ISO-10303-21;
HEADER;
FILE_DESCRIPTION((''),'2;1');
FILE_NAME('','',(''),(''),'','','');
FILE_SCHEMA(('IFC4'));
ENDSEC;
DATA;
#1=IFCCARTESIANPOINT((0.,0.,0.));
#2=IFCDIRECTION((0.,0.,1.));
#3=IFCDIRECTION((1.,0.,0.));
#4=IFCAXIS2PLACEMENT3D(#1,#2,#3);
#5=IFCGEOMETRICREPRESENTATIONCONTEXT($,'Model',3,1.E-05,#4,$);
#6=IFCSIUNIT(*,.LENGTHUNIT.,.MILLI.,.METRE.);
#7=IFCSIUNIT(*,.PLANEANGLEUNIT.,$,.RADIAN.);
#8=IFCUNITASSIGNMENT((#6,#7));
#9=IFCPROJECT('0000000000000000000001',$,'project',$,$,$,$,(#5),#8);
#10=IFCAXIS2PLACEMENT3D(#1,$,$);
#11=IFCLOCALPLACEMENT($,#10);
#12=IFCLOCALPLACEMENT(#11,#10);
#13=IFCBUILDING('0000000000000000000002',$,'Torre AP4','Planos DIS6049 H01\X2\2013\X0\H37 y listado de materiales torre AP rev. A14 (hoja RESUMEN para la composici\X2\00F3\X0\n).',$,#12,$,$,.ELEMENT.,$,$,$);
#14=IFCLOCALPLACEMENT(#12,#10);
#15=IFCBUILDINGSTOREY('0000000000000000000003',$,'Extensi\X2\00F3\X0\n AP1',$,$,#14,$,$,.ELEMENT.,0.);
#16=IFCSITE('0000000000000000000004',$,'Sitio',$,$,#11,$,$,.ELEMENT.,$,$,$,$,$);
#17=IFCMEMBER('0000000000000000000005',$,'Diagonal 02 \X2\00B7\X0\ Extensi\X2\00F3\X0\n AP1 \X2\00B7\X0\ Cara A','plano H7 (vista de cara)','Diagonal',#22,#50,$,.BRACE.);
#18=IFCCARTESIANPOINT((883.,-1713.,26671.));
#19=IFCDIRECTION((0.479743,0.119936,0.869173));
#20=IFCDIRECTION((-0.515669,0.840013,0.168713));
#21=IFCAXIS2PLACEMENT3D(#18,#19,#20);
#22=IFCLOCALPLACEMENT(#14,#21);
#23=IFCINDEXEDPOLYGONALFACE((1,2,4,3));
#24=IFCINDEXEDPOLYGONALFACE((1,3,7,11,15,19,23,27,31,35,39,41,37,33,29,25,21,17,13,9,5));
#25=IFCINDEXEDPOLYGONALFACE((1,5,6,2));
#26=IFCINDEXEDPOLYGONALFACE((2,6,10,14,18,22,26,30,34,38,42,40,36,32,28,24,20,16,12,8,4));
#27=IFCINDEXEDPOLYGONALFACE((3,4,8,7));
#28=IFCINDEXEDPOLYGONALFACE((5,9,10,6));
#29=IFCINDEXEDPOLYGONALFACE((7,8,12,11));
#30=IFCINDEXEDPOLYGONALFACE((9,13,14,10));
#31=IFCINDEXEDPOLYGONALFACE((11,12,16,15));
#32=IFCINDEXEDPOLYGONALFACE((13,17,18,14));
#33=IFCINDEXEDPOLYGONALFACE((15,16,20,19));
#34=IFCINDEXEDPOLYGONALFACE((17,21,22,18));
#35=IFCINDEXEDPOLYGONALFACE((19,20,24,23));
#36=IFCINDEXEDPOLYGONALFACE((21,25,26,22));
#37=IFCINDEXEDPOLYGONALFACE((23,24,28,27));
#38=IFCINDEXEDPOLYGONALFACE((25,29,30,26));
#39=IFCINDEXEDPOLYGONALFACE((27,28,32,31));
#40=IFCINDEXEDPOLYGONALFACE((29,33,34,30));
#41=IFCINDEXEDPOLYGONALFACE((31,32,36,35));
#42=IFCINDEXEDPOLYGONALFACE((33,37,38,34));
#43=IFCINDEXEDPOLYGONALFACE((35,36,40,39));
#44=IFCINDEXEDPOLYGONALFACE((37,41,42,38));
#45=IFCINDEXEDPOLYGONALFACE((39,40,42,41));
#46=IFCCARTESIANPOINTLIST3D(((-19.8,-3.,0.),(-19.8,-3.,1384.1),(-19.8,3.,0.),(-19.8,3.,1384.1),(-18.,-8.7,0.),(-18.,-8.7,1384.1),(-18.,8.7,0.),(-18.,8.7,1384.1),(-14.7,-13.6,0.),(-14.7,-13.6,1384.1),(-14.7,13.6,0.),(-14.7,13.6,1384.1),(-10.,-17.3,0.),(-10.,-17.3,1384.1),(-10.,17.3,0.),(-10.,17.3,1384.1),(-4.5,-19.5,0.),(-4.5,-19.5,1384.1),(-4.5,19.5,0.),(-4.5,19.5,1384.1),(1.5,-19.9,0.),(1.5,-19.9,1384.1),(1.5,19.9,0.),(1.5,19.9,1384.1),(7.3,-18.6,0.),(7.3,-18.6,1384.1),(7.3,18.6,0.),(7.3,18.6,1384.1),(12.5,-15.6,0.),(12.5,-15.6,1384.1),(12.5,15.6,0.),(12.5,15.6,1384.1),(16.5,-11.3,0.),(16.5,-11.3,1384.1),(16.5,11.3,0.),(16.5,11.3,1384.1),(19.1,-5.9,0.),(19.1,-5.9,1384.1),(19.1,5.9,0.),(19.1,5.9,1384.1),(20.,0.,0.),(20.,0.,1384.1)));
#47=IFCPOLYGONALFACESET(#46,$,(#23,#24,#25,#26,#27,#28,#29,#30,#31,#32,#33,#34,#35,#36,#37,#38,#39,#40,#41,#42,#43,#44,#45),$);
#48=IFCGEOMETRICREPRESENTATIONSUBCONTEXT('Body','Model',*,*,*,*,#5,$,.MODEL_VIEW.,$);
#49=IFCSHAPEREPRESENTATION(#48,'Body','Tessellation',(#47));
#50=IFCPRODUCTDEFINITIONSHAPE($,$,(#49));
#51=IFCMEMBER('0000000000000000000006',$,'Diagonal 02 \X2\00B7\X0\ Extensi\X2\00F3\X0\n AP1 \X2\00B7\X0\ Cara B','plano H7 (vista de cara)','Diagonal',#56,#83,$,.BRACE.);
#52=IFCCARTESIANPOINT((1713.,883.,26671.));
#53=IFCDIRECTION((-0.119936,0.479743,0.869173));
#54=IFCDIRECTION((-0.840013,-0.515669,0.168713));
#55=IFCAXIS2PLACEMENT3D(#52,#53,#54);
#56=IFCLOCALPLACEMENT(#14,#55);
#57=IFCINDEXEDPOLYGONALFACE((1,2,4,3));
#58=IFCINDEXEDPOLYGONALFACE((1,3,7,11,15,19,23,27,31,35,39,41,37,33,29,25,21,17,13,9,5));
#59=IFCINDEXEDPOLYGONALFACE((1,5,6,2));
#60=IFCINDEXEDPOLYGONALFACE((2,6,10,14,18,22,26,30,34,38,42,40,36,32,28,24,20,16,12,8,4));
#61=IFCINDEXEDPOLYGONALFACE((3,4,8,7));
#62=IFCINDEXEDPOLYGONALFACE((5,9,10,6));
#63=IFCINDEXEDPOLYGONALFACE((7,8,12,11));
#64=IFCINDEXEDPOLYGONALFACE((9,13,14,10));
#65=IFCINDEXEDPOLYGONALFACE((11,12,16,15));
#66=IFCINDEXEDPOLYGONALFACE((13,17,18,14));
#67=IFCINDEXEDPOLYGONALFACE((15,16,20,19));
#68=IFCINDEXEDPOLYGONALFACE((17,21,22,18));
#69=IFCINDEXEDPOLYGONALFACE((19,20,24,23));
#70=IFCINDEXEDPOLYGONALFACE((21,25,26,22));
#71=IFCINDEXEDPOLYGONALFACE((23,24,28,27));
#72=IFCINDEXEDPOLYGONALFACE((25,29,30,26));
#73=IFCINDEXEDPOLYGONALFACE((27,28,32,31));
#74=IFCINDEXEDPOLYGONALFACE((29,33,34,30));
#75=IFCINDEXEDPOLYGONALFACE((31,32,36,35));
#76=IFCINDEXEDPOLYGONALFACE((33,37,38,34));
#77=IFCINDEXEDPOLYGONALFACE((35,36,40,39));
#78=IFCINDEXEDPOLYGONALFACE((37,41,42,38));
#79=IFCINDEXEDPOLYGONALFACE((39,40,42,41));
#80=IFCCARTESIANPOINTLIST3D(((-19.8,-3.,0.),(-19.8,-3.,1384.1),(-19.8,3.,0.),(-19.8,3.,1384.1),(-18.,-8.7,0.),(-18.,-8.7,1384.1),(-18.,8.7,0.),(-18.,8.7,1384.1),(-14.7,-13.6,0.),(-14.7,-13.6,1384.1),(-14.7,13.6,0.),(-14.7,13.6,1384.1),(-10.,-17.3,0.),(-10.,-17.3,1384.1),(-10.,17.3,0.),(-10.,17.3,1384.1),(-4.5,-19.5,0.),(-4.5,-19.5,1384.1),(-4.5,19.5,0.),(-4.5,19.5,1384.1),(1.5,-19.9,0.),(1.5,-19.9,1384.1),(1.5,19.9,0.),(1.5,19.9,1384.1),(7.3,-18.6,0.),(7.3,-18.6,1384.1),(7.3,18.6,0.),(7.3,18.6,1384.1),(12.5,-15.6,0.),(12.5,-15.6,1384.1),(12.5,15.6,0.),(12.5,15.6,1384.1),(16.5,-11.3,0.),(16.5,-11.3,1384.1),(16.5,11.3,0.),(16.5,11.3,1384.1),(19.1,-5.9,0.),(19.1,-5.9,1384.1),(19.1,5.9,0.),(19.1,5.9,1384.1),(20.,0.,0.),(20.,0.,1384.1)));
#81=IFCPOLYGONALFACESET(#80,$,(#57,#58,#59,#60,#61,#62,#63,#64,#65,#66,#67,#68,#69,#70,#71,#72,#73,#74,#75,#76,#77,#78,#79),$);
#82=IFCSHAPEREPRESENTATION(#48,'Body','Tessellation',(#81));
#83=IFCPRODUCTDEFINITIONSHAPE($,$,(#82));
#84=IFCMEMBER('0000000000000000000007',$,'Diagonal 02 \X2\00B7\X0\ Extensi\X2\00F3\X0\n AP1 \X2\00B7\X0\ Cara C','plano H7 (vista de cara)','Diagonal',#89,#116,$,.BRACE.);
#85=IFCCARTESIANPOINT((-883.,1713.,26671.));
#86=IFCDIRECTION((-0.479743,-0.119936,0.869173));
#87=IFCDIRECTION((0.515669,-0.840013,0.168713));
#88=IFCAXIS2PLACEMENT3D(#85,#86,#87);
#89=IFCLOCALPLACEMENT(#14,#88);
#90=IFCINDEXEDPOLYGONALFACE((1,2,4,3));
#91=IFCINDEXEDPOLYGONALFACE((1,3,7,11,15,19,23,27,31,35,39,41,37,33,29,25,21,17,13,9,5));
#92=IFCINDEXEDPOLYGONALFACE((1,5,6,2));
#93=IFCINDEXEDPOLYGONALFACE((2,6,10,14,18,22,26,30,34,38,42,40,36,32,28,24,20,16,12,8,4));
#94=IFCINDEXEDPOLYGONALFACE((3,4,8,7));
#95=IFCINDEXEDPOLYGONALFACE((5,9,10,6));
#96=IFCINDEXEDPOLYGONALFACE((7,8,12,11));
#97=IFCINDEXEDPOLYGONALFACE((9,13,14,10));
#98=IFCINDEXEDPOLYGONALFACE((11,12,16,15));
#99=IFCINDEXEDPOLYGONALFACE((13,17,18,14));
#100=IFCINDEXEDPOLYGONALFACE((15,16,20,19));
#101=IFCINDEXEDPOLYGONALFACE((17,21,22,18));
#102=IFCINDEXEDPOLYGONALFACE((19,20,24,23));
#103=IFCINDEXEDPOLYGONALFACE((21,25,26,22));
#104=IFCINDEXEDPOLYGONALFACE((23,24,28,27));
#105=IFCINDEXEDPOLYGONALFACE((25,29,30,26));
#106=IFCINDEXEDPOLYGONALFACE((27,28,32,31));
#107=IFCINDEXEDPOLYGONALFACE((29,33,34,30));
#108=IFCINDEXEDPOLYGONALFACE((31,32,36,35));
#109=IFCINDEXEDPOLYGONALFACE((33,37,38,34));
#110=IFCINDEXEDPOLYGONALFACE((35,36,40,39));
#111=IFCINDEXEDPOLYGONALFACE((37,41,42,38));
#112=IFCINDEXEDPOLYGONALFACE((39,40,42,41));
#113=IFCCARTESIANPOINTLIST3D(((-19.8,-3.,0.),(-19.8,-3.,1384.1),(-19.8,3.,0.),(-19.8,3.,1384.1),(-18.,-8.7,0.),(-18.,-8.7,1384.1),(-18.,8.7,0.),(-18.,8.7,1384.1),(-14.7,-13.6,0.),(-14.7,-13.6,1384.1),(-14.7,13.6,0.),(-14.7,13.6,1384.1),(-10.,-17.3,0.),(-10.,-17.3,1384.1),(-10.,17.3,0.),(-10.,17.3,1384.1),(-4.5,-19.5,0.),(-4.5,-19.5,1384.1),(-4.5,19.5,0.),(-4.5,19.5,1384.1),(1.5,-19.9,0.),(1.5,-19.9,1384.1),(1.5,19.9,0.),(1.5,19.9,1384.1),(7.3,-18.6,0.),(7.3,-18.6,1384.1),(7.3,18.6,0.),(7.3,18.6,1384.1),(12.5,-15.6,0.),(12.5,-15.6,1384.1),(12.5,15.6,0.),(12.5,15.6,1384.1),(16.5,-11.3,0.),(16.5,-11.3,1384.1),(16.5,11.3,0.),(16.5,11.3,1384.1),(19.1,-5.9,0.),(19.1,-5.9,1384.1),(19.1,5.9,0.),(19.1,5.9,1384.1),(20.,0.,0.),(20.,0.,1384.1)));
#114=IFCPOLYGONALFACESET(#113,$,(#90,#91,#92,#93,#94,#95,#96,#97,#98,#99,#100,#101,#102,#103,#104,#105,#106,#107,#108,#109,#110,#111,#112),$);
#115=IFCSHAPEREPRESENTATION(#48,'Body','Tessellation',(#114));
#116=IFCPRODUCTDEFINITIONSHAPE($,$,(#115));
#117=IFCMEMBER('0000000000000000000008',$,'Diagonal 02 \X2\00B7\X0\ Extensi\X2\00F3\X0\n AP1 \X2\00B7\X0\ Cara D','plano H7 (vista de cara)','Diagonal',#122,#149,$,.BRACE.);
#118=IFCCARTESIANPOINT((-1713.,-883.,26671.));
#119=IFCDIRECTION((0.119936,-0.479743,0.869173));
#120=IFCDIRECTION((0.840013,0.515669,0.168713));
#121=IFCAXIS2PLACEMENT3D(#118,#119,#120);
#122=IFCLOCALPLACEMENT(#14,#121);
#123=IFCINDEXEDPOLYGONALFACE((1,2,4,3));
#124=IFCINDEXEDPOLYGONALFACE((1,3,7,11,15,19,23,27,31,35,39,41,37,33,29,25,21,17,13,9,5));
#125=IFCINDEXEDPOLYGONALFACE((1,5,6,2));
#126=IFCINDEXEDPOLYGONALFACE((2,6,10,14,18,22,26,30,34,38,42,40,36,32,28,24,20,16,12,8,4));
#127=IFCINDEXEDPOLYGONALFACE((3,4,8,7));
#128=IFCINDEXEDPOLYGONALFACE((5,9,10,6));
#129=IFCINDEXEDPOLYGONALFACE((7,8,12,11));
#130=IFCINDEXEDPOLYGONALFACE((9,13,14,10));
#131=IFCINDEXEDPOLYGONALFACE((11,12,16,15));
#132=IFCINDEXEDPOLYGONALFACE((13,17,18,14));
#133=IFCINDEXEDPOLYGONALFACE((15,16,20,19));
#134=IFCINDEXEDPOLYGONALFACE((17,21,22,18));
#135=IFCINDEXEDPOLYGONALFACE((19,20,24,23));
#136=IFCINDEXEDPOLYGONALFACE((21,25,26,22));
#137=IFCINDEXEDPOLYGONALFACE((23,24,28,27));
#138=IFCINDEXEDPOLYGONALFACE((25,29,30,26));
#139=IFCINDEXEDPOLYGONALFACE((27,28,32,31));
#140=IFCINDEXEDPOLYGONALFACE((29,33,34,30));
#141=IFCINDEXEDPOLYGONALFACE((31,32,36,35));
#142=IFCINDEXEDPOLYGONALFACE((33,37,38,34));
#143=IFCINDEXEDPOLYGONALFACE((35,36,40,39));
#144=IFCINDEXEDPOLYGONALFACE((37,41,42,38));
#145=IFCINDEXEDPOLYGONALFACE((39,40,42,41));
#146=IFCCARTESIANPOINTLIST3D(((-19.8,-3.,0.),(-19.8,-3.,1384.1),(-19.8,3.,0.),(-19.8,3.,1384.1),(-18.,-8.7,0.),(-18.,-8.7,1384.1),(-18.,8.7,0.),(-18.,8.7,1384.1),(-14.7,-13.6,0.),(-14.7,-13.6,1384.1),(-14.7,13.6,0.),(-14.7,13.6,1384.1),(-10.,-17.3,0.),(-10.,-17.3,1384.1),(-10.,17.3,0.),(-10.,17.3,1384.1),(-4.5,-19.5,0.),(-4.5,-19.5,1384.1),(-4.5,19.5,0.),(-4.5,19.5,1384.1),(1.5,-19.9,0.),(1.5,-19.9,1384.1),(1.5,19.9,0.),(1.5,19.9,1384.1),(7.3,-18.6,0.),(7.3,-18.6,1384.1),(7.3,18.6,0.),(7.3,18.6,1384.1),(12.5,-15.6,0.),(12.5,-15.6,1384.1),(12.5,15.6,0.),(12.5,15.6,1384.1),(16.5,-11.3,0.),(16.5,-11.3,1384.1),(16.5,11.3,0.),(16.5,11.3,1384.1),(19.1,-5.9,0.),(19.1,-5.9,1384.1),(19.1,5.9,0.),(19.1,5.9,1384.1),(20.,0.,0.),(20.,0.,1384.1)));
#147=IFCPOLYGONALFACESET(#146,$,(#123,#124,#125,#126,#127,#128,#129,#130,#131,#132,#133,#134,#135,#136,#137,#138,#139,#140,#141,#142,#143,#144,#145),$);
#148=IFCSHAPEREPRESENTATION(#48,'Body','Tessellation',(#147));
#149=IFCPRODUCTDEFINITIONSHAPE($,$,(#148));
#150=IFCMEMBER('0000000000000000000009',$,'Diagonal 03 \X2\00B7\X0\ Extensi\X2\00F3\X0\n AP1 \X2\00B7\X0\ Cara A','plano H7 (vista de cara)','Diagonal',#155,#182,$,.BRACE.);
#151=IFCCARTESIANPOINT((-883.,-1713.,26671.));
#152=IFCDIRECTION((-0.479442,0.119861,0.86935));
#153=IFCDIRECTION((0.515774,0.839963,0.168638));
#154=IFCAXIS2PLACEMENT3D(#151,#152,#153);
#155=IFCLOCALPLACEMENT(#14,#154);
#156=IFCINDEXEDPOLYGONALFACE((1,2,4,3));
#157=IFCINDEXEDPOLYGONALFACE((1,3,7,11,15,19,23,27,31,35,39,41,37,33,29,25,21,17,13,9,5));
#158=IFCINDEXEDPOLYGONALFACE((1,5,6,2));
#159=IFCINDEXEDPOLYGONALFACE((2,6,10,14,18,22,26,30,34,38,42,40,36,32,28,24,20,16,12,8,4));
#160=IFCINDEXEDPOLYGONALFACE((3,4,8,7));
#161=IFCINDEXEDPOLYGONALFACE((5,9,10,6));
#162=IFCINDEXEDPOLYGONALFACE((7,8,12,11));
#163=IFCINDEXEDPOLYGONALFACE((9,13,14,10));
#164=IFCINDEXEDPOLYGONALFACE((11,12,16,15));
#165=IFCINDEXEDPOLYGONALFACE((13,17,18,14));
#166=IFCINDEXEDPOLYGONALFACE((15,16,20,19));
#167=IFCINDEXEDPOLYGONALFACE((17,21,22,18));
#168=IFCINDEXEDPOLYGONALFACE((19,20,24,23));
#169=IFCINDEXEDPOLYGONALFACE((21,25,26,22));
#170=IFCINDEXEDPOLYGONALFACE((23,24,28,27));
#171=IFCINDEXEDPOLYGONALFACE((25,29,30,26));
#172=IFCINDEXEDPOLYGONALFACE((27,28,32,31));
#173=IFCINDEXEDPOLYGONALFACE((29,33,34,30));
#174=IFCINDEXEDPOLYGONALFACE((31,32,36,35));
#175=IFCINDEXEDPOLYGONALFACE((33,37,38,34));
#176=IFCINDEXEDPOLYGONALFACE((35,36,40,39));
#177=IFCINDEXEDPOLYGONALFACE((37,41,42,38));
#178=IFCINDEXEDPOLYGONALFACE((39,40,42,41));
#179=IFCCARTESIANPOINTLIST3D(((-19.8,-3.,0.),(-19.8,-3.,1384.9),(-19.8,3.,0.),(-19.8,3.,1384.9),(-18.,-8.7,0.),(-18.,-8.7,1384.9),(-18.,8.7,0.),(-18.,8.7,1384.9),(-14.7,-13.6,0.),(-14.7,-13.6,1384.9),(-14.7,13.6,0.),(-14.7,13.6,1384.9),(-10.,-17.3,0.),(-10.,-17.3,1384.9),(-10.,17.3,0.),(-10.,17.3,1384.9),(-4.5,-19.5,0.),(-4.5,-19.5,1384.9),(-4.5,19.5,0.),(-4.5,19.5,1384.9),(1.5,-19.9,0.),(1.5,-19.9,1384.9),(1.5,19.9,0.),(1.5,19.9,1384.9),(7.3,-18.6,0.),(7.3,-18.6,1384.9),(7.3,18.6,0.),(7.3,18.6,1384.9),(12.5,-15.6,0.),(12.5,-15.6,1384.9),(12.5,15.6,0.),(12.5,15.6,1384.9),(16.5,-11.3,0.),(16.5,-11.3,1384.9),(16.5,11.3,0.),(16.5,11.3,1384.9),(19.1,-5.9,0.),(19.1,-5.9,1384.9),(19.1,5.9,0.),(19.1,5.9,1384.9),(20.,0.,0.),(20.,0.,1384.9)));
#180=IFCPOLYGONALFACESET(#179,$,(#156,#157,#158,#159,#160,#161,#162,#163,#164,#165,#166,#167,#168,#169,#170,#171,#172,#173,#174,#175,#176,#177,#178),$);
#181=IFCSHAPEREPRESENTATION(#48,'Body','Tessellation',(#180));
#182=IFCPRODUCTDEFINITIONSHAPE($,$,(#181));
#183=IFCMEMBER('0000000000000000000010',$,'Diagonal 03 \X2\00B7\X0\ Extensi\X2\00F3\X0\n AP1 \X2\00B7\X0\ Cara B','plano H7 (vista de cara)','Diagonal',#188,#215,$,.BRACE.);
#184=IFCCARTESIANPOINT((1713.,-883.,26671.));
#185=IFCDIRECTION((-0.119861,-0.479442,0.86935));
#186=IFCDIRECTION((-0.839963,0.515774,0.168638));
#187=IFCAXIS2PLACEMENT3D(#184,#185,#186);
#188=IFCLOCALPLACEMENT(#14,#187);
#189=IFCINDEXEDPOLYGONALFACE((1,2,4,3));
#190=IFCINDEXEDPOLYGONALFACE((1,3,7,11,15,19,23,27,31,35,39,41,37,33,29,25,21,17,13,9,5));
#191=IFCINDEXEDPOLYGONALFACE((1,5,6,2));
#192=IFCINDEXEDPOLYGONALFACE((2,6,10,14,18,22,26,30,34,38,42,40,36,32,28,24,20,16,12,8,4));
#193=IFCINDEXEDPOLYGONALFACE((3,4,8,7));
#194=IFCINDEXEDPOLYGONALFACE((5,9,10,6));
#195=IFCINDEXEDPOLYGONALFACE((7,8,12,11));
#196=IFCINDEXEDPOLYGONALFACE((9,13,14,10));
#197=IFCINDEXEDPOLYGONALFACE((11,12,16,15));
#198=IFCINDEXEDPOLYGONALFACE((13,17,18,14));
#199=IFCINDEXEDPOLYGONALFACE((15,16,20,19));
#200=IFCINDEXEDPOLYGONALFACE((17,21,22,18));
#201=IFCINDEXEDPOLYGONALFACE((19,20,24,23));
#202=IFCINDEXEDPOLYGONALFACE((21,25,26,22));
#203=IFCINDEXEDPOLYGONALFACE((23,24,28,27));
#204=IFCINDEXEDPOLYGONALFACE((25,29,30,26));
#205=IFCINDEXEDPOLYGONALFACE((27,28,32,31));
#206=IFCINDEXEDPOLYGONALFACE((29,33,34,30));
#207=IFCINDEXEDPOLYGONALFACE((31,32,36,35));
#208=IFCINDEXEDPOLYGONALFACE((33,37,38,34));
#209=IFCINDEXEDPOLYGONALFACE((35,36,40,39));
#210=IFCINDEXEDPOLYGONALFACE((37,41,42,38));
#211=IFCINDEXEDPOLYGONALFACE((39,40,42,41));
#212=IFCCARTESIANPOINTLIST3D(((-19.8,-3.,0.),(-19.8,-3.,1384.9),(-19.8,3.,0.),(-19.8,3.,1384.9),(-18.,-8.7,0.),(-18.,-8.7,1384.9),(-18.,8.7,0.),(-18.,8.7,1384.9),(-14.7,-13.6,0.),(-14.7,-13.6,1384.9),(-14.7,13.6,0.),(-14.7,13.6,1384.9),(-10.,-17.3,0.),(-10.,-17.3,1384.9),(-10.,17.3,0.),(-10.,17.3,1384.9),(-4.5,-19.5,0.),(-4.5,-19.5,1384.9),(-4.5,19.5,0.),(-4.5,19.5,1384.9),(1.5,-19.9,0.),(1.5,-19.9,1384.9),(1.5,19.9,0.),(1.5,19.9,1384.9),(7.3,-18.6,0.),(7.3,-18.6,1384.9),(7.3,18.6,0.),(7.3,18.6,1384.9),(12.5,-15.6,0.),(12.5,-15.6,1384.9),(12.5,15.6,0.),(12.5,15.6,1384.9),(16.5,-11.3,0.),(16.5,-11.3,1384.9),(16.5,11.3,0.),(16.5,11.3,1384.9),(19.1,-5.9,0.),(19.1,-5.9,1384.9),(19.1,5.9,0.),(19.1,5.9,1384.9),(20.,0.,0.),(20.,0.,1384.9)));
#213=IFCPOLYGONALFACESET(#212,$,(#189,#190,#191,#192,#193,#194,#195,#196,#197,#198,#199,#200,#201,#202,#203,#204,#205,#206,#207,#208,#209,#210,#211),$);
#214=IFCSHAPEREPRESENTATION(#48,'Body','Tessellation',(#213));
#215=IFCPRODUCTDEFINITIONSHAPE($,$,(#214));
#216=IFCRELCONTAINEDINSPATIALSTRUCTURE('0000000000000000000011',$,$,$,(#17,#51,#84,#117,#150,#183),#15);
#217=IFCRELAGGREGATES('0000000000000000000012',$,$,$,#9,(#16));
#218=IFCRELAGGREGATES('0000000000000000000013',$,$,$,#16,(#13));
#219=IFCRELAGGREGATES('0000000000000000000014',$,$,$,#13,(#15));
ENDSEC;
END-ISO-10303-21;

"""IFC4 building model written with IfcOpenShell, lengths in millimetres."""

from ifc_helpers import new_model, si_unit, frame, origin, origin_with_axes, place, context, subcontext, project, spatial, circle, extrude, element, save


model = new_model("IFC4")

# Units and contexts
model_context = context("Model", 3, precision=1e-05, world=origin_with_axes())
body_context = subcontext(model_context, "Body", "Model", "MODEL_VIEW")
ifc_project = project(units=[si_unit("LENGTHUNIT", "METRE", prefix="MILLI"), si_unit("PLANEANGLEUNIT", "RADIAN")], contexts=[model_context])

# Site, building, storey
site_placement = place(None, origin())
site = spatial("IfcSite", under=ifc_project, at=site_placement, Name="Sitio", CompositionType="ELEMENT")
building_placement = place(site_placement, origin())
building = spatial("IfcBuilding", under=site, at=building_placement, Name="Torre AP4", Description="Planos DIS6049 H01–H37 y listado de materiales torre AP rev. A14 (hoja RESUMEN para la composición).", CompositionType="ELEMENT")
storey_placement = place(building_placement, origin())
storey = spatial("IfcBuildingStorey", under=building, at=storey_placement, Name="Extensión AP1", CompositionType="ELEMENT", Elevation=0.0)

# Members
for number, where, z_axis, x_axis, name in (
    (1, (883.0, -1713.0, 26671.0), (0.479743, 0.119936, 0.869173), (-0.515669, 0.840013, 0.168713), "Diagonal 02 · Extensión AP1 · Cara A"),
    (2, (1713.0, 883.0, 26671.0), (-0.119936, 0.479743, 0.869173), (-0.840013, -0.515669, 0.168713), "Diagonal 02 · Extensión AP1 · Cara B"),
    (3, (-883.0, 1713.0, 26671.0), (-0.479743, -0.119936, 0.869173), (0.515669, -0.840013, 0.168713), "Diagonal 02 · Extensión AP1 · Cara C"),
    (4, (-1713.0, -883.0, 26671.0), (0.119936, -0.479743, 0.869173), (0.840013, 0.515669, 0.168713), "Diagonal 02 · Extensión AP1 · Cara D"),
):
    element("IfcMember", number, at=place(storey_placement, frame(where, z_axis=z_axis, x_axis=x_axis)), inside=storey, Name=name, Description="plano H7 (vista de cara)", ObjectType="Diagonal", PredefinedType="BRACE", context=body_context, shape_type="SweptSolid", body=[
        extrude(circle(Radius=20.0), None, (0.0, 0.0, 1.0), 1384.1),
    ])
for number, where, z_axis, x_axis, name in (
    (5, (-883.0, -1713.0, 26671.0), (-0.479442, 0.119861, 0.86935), (0.515774, 0.839963, 0.168638), "Diagonal 03 · Extensión AP1 · Cara A"),
    (6, (1713.0, -883.0, 26671.0), (-0.119861, -0.479442, 0.86935), (-0.839963, 0.515774, 0.168638), "Diagonal 03 · Extensión AP1 · Cara B"),
):
    element("IfcMember", number, at=place(storey_placement, frame(where, z_axis=z_axis, x_axis=x_axis)), inside=storey, Name=name, Description="plano H7 (vista de cara)", ObjectType="Diagonal", PredefinedType="BRACE", context=body_context, shape_type="SweptSolid", body=[
        extrude(circle(Radius=20.0), None, (0.0, 0.0, 1.0), 1384.9),
    ])

save(model, "model.ifc")
